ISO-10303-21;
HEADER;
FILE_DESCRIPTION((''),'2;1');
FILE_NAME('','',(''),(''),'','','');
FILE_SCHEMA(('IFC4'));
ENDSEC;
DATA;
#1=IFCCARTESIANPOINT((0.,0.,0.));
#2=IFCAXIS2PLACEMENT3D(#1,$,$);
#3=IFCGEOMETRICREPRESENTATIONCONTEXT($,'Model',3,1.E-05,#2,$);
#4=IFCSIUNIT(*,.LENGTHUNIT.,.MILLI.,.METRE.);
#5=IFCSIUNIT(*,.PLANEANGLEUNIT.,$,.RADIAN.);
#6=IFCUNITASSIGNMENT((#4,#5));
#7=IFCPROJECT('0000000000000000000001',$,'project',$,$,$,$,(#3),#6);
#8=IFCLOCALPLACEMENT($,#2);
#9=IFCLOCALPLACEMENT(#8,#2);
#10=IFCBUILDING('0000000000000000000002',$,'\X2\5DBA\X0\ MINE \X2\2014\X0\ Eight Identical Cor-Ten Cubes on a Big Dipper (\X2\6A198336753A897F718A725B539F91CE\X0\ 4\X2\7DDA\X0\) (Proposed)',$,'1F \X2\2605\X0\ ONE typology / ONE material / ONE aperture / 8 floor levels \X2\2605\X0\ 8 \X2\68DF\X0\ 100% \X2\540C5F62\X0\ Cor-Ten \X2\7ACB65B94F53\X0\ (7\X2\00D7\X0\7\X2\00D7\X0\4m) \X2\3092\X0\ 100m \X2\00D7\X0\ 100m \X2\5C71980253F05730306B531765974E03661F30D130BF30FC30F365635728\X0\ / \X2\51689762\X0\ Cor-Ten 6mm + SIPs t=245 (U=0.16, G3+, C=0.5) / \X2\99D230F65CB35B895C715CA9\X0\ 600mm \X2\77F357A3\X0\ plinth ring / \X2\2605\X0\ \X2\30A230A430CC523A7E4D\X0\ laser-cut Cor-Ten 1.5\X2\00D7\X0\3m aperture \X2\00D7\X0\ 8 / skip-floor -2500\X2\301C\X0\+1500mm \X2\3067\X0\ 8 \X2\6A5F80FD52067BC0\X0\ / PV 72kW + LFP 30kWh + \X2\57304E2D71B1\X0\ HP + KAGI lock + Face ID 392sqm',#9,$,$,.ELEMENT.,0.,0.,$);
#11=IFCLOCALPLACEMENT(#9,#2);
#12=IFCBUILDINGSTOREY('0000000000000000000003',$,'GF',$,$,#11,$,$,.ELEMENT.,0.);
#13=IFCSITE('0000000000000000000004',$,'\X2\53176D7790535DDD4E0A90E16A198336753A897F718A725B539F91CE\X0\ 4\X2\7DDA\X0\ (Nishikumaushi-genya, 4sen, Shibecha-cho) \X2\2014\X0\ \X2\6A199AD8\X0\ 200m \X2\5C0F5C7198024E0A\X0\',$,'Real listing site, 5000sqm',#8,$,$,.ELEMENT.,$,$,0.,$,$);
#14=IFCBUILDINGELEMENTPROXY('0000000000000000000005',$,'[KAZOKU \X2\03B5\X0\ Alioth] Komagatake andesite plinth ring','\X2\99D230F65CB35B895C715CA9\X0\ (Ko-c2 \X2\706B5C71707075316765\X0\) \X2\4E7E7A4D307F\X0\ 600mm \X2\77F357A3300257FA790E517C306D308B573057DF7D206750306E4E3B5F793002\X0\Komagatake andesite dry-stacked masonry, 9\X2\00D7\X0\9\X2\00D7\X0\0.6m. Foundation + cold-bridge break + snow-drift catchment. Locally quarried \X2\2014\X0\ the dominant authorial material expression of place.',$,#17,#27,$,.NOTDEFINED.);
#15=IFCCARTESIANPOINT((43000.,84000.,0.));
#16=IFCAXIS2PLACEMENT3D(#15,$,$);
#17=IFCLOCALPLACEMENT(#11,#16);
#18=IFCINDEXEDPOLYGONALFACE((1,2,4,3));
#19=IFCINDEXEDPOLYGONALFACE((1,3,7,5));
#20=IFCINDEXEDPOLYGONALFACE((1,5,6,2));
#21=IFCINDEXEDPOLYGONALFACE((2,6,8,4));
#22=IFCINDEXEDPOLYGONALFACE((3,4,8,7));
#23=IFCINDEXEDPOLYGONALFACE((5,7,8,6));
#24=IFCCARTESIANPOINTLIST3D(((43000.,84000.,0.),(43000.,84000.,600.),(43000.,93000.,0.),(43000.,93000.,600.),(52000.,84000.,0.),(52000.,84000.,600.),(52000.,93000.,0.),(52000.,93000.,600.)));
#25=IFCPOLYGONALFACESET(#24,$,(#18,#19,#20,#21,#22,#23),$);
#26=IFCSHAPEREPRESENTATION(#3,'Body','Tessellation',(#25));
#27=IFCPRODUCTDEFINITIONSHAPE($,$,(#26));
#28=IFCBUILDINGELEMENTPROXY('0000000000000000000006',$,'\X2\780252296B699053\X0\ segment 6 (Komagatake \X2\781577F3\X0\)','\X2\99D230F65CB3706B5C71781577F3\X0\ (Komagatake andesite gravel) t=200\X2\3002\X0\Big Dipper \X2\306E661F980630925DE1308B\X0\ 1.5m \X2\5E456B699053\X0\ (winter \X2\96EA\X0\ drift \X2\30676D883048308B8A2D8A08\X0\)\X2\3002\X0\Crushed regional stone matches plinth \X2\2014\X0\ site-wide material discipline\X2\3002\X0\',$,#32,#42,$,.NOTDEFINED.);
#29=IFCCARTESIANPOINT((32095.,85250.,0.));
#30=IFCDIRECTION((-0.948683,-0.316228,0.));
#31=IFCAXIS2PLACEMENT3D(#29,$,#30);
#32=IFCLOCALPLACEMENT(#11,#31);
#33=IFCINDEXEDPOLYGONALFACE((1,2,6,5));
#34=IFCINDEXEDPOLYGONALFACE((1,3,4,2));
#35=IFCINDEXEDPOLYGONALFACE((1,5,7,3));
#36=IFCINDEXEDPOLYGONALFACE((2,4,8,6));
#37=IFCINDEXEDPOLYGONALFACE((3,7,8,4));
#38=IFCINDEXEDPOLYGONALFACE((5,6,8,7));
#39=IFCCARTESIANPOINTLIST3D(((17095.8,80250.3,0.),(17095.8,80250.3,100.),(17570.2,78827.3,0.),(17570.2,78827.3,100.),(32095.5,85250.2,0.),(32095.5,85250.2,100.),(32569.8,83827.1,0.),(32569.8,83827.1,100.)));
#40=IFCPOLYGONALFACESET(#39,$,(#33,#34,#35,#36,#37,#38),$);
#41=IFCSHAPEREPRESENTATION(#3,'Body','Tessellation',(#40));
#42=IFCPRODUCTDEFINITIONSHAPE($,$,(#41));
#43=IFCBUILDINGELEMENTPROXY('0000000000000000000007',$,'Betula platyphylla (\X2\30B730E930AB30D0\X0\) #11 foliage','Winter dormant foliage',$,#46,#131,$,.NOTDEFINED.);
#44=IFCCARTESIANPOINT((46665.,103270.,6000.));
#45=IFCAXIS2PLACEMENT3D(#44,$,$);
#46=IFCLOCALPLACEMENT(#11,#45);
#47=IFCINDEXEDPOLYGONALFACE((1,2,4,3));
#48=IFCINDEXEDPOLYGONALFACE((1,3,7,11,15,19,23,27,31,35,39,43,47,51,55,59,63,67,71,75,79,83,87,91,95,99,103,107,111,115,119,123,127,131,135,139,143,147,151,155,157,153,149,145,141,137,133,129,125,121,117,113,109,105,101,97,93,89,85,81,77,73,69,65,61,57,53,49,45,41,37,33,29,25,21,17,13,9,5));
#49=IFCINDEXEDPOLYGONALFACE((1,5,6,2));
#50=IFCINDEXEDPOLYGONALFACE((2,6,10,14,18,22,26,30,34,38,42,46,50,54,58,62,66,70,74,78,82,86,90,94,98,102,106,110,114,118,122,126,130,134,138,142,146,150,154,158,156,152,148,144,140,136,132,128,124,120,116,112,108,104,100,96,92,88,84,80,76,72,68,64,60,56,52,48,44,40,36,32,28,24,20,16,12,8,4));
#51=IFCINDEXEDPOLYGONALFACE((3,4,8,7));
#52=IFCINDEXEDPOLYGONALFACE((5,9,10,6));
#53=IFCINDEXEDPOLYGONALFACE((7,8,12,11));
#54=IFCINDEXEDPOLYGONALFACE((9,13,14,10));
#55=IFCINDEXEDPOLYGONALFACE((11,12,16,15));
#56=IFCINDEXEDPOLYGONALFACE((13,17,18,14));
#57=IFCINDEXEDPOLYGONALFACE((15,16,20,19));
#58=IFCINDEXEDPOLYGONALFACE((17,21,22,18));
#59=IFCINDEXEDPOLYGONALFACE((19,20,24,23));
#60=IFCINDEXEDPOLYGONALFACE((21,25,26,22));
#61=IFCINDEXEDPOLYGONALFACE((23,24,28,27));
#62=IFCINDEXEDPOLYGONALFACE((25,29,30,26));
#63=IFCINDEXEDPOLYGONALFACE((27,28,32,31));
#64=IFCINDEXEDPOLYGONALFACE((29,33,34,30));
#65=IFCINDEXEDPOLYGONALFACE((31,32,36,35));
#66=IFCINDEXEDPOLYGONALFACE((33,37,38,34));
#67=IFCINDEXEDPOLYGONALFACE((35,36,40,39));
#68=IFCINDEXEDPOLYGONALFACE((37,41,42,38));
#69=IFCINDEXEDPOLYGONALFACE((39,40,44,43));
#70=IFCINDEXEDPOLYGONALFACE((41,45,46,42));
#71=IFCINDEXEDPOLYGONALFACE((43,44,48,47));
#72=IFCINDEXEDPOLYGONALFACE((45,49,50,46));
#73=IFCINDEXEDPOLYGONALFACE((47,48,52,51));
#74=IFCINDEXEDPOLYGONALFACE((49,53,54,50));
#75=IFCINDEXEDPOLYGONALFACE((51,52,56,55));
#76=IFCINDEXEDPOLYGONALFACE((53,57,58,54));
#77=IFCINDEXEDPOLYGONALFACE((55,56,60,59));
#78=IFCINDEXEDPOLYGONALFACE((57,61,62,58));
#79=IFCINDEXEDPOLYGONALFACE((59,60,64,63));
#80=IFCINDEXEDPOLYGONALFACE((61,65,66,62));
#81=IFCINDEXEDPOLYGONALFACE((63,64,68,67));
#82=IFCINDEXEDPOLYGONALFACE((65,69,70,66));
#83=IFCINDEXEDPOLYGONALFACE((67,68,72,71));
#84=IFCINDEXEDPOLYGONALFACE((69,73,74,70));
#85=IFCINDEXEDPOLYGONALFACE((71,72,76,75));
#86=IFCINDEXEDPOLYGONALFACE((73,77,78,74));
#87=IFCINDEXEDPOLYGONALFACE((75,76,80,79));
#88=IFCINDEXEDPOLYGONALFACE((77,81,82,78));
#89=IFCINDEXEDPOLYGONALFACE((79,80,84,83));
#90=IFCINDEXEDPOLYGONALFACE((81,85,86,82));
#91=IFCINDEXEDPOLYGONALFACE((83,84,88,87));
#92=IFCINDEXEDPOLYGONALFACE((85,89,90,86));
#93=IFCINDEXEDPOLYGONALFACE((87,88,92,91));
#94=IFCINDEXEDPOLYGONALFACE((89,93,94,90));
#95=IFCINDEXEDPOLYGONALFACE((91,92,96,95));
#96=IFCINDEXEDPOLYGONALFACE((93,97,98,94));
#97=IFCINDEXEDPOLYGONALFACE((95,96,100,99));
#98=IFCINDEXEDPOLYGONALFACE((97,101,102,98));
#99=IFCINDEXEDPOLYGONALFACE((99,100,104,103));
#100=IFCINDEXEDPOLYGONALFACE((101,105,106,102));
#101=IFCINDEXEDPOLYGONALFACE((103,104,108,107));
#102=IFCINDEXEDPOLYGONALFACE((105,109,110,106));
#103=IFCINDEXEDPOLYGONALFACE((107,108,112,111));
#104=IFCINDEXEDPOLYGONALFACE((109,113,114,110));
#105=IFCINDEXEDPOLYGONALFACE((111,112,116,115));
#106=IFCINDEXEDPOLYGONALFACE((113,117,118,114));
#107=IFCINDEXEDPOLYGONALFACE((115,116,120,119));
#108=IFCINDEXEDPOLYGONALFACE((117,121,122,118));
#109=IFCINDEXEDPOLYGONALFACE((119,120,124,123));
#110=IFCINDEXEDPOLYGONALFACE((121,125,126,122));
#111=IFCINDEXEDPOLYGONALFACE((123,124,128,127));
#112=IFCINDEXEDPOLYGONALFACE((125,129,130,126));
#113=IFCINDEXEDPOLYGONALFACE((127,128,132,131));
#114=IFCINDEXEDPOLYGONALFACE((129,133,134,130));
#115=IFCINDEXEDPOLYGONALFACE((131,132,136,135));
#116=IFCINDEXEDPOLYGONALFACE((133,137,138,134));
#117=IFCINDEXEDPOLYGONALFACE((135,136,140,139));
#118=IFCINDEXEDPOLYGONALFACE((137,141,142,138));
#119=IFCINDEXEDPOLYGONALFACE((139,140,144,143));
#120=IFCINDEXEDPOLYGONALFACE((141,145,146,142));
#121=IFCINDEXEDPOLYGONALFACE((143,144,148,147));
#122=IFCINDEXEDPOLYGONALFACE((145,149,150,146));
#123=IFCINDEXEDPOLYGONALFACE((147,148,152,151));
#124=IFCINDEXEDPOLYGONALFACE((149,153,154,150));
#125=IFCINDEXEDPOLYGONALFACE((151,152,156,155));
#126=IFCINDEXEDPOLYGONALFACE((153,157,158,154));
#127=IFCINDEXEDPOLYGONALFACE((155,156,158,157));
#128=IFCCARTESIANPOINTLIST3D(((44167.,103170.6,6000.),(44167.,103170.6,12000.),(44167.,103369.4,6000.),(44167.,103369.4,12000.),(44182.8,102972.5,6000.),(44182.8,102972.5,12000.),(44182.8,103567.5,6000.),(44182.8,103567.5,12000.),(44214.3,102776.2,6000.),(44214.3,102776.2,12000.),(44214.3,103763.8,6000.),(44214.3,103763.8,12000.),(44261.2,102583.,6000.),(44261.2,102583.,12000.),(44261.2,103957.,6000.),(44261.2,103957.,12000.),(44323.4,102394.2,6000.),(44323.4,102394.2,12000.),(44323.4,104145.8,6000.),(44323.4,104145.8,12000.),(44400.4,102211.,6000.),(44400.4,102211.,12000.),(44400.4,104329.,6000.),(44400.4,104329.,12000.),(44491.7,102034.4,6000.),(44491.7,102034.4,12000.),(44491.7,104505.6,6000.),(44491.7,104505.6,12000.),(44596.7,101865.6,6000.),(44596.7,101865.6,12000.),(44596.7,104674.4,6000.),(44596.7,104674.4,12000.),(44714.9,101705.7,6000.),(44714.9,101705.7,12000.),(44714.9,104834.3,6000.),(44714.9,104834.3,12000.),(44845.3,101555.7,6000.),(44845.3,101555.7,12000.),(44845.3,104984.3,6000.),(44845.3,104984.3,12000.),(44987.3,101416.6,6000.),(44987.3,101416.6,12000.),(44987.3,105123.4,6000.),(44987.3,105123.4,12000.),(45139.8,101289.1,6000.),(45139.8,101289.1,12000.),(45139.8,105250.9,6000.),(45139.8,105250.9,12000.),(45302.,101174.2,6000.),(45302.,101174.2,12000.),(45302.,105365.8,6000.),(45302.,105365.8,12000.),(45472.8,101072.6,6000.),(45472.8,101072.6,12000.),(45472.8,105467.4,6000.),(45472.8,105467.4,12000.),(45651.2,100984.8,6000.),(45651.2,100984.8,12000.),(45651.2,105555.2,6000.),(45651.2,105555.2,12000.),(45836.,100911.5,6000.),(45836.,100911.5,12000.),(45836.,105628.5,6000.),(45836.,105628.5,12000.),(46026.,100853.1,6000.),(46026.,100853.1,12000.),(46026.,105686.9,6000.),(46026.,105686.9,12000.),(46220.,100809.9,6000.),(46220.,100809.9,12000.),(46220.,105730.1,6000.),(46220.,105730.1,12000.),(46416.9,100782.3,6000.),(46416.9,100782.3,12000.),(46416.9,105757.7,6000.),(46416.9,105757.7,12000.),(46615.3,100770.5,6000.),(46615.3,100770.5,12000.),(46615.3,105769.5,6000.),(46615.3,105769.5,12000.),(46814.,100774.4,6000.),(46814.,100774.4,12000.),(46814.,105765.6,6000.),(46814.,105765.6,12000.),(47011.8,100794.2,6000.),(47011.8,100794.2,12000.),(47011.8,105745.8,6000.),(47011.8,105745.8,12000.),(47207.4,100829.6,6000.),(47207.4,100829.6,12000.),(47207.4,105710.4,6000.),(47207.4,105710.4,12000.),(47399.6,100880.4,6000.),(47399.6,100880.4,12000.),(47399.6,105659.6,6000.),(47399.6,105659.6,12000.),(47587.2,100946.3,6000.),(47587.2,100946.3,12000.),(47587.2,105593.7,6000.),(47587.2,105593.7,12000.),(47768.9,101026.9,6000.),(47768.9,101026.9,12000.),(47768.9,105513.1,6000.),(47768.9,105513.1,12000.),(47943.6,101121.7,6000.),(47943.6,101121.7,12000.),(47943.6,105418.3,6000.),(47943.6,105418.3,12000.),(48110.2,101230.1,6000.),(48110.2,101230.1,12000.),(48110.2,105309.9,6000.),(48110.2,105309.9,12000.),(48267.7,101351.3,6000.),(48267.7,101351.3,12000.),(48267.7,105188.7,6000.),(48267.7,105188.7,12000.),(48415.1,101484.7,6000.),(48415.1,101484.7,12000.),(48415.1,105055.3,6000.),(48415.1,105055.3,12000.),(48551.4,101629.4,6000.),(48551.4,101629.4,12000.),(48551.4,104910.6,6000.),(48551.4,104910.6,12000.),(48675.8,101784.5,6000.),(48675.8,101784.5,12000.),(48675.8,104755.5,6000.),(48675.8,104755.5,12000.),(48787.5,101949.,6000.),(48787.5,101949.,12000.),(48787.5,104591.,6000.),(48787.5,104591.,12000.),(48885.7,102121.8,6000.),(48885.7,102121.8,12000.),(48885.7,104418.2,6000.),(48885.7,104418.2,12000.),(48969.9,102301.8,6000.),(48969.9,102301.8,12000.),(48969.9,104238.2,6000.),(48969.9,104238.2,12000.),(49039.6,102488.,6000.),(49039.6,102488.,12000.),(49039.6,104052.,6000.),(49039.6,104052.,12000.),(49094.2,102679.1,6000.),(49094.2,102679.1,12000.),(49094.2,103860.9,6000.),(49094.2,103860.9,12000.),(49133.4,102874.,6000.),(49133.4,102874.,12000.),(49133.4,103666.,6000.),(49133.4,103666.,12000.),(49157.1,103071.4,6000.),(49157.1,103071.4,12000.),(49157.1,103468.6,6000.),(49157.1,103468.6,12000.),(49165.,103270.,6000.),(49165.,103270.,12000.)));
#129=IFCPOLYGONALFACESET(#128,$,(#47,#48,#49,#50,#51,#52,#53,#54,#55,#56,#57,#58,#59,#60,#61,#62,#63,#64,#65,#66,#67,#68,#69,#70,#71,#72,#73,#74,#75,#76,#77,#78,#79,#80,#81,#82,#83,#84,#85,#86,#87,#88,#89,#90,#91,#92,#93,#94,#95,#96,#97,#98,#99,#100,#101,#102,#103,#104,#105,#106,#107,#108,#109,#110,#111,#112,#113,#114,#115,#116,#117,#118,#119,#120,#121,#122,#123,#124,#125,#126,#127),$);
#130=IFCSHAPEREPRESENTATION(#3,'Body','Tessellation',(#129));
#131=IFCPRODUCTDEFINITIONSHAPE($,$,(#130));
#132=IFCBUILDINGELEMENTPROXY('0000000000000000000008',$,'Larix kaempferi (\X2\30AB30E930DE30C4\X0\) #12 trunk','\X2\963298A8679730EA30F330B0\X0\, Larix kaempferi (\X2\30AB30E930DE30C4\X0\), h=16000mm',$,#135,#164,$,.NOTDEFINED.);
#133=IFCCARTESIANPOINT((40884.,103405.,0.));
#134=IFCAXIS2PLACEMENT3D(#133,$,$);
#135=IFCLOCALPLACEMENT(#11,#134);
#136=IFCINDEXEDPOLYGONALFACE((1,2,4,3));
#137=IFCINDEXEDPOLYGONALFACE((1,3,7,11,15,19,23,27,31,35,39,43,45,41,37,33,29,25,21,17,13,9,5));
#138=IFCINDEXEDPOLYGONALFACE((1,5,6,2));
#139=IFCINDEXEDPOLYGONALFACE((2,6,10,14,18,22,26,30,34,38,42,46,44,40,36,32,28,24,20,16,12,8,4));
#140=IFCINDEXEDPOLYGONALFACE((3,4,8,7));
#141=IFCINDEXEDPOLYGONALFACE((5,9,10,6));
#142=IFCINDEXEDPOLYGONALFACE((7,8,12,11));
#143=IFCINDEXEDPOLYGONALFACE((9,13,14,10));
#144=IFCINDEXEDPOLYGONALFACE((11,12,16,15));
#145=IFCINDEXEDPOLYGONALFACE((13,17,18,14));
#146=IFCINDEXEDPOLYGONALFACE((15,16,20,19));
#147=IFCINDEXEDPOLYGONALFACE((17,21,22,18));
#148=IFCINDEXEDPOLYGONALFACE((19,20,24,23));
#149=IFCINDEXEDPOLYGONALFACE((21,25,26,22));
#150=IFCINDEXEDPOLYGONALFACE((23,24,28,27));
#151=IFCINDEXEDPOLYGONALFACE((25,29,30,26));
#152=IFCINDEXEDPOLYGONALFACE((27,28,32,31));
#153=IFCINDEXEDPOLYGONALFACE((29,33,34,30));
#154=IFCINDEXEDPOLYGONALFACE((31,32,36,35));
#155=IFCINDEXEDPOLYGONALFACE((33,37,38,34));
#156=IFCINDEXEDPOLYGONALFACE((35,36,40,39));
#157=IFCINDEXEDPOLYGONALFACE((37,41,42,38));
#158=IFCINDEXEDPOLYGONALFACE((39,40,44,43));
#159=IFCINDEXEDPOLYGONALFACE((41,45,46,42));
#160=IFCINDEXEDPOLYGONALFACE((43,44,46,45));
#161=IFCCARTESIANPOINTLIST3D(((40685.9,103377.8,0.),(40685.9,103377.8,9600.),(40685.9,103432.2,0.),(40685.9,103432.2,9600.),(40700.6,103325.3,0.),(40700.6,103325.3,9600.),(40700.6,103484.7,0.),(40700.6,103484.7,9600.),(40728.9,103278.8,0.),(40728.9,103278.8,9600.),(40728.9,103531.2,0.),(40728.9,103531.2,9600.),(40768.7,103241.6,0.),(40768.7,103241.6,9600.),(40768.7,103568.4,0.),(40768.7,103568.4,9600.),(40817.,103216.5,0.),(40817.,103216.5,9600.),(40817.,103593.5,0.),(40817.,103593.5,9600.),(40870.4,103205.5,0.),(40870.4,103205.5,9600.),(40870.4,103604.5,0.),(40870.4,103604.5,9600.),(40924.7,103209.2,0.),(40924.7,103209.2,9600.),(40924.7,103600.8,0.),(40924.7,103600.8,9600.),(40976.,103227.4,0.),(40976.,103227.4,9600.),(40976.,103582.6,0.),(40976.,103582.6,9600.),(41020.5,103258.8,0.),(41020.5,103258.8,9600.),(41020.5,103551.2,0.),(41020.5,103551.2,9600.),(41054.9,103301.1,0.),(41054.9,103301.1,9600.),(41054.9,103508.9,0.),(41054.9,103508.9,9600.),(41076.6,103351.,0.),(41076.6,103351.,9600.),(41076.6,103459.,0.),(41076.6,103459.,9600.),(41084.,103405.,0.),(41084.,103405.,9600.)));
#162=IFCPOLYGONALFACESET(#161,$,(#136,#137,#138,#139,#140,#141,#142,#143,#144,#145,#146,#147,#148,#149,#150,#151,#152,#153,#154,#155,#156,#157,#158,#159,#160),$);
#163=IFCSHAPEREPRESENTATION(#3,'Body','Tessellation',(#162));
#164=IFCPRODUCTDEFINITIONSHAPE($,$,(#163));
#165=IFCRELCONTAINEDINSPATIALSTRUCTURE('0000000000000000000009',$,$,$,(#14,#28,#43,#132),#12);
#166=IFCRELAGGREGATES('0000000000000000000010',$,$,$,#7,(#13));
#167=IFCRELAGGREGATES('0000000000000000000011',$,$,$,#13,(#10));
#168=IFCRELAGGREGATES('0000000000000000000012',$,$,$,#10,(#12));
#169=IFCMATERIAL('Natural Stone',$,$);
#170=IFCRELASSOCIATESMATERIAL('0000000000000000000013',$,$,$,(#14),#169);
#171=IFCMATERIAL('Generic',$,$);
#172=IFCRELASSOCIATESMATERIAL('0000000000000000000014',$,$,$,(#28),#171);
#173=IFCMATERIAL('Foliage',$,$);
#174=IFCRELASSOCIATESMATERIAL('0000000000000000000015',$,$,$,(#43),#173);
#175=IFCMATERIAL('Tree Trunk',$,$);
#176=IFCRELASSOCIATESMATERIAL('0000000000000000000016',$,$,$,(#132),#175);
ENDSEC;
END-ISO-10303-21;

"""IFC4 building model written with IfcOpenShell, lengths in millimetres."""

from ifc_helpers import new_model, si_unit, frame, frame_2d, origin, origin_2d, place, context, project, spatial, rectangle, circle, extrude, material, element, save


model = new_model("IFC4")

# Units and contexts
model_context = context("Model", 3, precision=1e-05, world=origin())
ifc_project = project(units=[si_unit("LENGTHUNIT", "METRE", prefix="MILLI"), si_unit("PLANEANGLEUNIT", "RADIAN")], contexts=[model_context])

# Site, building, storey
site_placement = place(None, origin())
site = spatial("IfcSite", under=ifc_project, at=site_placement, Name="北海道川上郡標茶町西熊牛原野 4線 (Nishikumaushi-genya, 4sen, Shibecha-cho) — 標高 200m 小山頂上", ObjectType="Real listing site, 5000sqm", CompositionType="ELEMENT", RefElevation=0.0)
building_placement = place(site_placement, origin())
building = spatial("IfcBuilding", under=site, at=building_placement, Name="嶺 MINE — Eight Identical Cor-Ten Cubes on a Big Dipper (標茶町西熊牛原野 4線) (Proposed)", ObjectType="1F ★ ONE typology / ONE material / ONE aperture / 8 floor levels ★ 8 棟 100% 同形 Cor-Ten 立方体 (7×7×4m) を 100m × 100m 山頂台地に北斗七星パターン散在 / 全面 Cor-Ten 6mm + SIPs t=245 (U=0.16, G3+, C=0.5) / 駒ヶ岳安山岩 600mm 石垣 plinth ring / ★ アイヌ刺繍 laser-cut Cor-Ten 1.5×3m aperture × 8 / skip-floor -2500〜+1500mm で 8 機能分節 / PV 72kW + LFP 30kWh + 地中熱 HP + KAGI lock + Face ID 392sqm", CompositionType="ELEMENT", ElevationOfRefHeight=0.0, ElevationOfTerrain=0.0)
storey_placement = place(building_placement, origin())
storey = spatial("IfcBuildingStorey", under=building, at=storey_placement, Name="GF", CompositionType="ELEMENT", Elevation=0.0)

# Shared definitions
ifc_material_1 = material(Name="Generic")

# Building element proxies
ifc_material_2 = material(Name="Natural Stone")
proxy_1_placement = place(storey_placement, frame((43000.0, 84000.0, 0.0)))
element("IfcBuildingElementProxy", 1, at=proxy_1_placement, inside=storey, material=ifc_material_2, Name="[KAZOKU ε Alioth] Komagatake andesite plinth ring", Description="駒ヶ岳安山岩 (Ko-c2 火山灰由来) 乾積み 600mm 石垣。基礎兼ねる地域素材の主役。Komagatake andesite dry-stacked masonry, 9×9×0.6m. Foundation + cold-bridge break + snow-drift catchment. Locally quarried — the dominant authorial material expression of place.", PredefinedType="NOTDEFINED", context=model_context, shape_type="SweptSolid", body=[
    extrude(rectangle(XDim=9000.0, YDim=9000.0, at=frame_2d((4500.0, 4500.0))), frame((43000.0, 84000.0, 0.0)), (0.0, 0.0, 1.0), 600.0),
])
proxy_2_placement = place(storey_placement, frame((32095.0, 85250.0, 0.0), x_axis=(-0.948683, -0.316228, 0.0)))
element("IfcBuildingElementProxy", 2, at=proxy_2_placement, inside=storey, material=ifc_material_1, Name="砂利歩道 segment 6 (Komagatake 砕石)", Description="駒ヶ岳火山砕石 (Komagatake andesite gravel) t=200。Big Dipper の星順を巡る 1.5m 幅歩道 (winter 雪 drift で消える設計)。Crushed regional stone matches plinth — site-wide material discipline。", PredefinedType="NOTDEFINED", context=model_context, shape_type="SweptSolid", body=[
    extrude(rectangle(XDim=15811.0, YDim=1500.0, at=frame_2d((7905.0, 750.0))), frame((32095.0, 85250.0, 0.0), x_axis=(-0.948683, -0.316228, 0.0)), (0.0, 0.0, 1.0), 100.0),
])
ifc_material_3 = material(Name="Foliage")
proxy_3_placement = place(storey_placement, frame((46665.0, 103270.0, 6000.0)))
element("IfcBuildingElementProxy", 3, at=proxy_3_placement, inside=storey, material=ifc_material_3, Name="Betula platyphylla (シラカバ) #11 foliage", Description="Winter dormant foliage", PredefinedType="NOTDEFINED", context=model_context, shape_type="SweptSolid", body=[
    extrude(circle(Radius=2500.0, at=origin_2d()), frame((46665.0, 103270.0, 6000.0)), (0.0, 0.0, 1.0), 6000.0),
])
ifc_material_4 = material(Name="Tree Trunk")
proxy_4_placement = place(storey_placement, frame((40884.0, 103405.0, 0.0)))
element("IfcBuildingElementProxy", 4, at=proxy_4_placement, inside=storey, material=ifc_material_4, Name="Larix kaempferi (カラマツ) #12 trunk", Description="防風林リング, Larix kaempferi (カラマツ), h=16000mm", PredefinedType="NOTDEFINED", context=model_context, shape_type="SweptSolid", body=[
    extrude(circle(Radius=200.0, at=origin_2d()), frame((40884.0, 103405.0, 0.0)), (0.0, 0.0, 1.0), 9600.0),
])

save(model, "model.ifc")
